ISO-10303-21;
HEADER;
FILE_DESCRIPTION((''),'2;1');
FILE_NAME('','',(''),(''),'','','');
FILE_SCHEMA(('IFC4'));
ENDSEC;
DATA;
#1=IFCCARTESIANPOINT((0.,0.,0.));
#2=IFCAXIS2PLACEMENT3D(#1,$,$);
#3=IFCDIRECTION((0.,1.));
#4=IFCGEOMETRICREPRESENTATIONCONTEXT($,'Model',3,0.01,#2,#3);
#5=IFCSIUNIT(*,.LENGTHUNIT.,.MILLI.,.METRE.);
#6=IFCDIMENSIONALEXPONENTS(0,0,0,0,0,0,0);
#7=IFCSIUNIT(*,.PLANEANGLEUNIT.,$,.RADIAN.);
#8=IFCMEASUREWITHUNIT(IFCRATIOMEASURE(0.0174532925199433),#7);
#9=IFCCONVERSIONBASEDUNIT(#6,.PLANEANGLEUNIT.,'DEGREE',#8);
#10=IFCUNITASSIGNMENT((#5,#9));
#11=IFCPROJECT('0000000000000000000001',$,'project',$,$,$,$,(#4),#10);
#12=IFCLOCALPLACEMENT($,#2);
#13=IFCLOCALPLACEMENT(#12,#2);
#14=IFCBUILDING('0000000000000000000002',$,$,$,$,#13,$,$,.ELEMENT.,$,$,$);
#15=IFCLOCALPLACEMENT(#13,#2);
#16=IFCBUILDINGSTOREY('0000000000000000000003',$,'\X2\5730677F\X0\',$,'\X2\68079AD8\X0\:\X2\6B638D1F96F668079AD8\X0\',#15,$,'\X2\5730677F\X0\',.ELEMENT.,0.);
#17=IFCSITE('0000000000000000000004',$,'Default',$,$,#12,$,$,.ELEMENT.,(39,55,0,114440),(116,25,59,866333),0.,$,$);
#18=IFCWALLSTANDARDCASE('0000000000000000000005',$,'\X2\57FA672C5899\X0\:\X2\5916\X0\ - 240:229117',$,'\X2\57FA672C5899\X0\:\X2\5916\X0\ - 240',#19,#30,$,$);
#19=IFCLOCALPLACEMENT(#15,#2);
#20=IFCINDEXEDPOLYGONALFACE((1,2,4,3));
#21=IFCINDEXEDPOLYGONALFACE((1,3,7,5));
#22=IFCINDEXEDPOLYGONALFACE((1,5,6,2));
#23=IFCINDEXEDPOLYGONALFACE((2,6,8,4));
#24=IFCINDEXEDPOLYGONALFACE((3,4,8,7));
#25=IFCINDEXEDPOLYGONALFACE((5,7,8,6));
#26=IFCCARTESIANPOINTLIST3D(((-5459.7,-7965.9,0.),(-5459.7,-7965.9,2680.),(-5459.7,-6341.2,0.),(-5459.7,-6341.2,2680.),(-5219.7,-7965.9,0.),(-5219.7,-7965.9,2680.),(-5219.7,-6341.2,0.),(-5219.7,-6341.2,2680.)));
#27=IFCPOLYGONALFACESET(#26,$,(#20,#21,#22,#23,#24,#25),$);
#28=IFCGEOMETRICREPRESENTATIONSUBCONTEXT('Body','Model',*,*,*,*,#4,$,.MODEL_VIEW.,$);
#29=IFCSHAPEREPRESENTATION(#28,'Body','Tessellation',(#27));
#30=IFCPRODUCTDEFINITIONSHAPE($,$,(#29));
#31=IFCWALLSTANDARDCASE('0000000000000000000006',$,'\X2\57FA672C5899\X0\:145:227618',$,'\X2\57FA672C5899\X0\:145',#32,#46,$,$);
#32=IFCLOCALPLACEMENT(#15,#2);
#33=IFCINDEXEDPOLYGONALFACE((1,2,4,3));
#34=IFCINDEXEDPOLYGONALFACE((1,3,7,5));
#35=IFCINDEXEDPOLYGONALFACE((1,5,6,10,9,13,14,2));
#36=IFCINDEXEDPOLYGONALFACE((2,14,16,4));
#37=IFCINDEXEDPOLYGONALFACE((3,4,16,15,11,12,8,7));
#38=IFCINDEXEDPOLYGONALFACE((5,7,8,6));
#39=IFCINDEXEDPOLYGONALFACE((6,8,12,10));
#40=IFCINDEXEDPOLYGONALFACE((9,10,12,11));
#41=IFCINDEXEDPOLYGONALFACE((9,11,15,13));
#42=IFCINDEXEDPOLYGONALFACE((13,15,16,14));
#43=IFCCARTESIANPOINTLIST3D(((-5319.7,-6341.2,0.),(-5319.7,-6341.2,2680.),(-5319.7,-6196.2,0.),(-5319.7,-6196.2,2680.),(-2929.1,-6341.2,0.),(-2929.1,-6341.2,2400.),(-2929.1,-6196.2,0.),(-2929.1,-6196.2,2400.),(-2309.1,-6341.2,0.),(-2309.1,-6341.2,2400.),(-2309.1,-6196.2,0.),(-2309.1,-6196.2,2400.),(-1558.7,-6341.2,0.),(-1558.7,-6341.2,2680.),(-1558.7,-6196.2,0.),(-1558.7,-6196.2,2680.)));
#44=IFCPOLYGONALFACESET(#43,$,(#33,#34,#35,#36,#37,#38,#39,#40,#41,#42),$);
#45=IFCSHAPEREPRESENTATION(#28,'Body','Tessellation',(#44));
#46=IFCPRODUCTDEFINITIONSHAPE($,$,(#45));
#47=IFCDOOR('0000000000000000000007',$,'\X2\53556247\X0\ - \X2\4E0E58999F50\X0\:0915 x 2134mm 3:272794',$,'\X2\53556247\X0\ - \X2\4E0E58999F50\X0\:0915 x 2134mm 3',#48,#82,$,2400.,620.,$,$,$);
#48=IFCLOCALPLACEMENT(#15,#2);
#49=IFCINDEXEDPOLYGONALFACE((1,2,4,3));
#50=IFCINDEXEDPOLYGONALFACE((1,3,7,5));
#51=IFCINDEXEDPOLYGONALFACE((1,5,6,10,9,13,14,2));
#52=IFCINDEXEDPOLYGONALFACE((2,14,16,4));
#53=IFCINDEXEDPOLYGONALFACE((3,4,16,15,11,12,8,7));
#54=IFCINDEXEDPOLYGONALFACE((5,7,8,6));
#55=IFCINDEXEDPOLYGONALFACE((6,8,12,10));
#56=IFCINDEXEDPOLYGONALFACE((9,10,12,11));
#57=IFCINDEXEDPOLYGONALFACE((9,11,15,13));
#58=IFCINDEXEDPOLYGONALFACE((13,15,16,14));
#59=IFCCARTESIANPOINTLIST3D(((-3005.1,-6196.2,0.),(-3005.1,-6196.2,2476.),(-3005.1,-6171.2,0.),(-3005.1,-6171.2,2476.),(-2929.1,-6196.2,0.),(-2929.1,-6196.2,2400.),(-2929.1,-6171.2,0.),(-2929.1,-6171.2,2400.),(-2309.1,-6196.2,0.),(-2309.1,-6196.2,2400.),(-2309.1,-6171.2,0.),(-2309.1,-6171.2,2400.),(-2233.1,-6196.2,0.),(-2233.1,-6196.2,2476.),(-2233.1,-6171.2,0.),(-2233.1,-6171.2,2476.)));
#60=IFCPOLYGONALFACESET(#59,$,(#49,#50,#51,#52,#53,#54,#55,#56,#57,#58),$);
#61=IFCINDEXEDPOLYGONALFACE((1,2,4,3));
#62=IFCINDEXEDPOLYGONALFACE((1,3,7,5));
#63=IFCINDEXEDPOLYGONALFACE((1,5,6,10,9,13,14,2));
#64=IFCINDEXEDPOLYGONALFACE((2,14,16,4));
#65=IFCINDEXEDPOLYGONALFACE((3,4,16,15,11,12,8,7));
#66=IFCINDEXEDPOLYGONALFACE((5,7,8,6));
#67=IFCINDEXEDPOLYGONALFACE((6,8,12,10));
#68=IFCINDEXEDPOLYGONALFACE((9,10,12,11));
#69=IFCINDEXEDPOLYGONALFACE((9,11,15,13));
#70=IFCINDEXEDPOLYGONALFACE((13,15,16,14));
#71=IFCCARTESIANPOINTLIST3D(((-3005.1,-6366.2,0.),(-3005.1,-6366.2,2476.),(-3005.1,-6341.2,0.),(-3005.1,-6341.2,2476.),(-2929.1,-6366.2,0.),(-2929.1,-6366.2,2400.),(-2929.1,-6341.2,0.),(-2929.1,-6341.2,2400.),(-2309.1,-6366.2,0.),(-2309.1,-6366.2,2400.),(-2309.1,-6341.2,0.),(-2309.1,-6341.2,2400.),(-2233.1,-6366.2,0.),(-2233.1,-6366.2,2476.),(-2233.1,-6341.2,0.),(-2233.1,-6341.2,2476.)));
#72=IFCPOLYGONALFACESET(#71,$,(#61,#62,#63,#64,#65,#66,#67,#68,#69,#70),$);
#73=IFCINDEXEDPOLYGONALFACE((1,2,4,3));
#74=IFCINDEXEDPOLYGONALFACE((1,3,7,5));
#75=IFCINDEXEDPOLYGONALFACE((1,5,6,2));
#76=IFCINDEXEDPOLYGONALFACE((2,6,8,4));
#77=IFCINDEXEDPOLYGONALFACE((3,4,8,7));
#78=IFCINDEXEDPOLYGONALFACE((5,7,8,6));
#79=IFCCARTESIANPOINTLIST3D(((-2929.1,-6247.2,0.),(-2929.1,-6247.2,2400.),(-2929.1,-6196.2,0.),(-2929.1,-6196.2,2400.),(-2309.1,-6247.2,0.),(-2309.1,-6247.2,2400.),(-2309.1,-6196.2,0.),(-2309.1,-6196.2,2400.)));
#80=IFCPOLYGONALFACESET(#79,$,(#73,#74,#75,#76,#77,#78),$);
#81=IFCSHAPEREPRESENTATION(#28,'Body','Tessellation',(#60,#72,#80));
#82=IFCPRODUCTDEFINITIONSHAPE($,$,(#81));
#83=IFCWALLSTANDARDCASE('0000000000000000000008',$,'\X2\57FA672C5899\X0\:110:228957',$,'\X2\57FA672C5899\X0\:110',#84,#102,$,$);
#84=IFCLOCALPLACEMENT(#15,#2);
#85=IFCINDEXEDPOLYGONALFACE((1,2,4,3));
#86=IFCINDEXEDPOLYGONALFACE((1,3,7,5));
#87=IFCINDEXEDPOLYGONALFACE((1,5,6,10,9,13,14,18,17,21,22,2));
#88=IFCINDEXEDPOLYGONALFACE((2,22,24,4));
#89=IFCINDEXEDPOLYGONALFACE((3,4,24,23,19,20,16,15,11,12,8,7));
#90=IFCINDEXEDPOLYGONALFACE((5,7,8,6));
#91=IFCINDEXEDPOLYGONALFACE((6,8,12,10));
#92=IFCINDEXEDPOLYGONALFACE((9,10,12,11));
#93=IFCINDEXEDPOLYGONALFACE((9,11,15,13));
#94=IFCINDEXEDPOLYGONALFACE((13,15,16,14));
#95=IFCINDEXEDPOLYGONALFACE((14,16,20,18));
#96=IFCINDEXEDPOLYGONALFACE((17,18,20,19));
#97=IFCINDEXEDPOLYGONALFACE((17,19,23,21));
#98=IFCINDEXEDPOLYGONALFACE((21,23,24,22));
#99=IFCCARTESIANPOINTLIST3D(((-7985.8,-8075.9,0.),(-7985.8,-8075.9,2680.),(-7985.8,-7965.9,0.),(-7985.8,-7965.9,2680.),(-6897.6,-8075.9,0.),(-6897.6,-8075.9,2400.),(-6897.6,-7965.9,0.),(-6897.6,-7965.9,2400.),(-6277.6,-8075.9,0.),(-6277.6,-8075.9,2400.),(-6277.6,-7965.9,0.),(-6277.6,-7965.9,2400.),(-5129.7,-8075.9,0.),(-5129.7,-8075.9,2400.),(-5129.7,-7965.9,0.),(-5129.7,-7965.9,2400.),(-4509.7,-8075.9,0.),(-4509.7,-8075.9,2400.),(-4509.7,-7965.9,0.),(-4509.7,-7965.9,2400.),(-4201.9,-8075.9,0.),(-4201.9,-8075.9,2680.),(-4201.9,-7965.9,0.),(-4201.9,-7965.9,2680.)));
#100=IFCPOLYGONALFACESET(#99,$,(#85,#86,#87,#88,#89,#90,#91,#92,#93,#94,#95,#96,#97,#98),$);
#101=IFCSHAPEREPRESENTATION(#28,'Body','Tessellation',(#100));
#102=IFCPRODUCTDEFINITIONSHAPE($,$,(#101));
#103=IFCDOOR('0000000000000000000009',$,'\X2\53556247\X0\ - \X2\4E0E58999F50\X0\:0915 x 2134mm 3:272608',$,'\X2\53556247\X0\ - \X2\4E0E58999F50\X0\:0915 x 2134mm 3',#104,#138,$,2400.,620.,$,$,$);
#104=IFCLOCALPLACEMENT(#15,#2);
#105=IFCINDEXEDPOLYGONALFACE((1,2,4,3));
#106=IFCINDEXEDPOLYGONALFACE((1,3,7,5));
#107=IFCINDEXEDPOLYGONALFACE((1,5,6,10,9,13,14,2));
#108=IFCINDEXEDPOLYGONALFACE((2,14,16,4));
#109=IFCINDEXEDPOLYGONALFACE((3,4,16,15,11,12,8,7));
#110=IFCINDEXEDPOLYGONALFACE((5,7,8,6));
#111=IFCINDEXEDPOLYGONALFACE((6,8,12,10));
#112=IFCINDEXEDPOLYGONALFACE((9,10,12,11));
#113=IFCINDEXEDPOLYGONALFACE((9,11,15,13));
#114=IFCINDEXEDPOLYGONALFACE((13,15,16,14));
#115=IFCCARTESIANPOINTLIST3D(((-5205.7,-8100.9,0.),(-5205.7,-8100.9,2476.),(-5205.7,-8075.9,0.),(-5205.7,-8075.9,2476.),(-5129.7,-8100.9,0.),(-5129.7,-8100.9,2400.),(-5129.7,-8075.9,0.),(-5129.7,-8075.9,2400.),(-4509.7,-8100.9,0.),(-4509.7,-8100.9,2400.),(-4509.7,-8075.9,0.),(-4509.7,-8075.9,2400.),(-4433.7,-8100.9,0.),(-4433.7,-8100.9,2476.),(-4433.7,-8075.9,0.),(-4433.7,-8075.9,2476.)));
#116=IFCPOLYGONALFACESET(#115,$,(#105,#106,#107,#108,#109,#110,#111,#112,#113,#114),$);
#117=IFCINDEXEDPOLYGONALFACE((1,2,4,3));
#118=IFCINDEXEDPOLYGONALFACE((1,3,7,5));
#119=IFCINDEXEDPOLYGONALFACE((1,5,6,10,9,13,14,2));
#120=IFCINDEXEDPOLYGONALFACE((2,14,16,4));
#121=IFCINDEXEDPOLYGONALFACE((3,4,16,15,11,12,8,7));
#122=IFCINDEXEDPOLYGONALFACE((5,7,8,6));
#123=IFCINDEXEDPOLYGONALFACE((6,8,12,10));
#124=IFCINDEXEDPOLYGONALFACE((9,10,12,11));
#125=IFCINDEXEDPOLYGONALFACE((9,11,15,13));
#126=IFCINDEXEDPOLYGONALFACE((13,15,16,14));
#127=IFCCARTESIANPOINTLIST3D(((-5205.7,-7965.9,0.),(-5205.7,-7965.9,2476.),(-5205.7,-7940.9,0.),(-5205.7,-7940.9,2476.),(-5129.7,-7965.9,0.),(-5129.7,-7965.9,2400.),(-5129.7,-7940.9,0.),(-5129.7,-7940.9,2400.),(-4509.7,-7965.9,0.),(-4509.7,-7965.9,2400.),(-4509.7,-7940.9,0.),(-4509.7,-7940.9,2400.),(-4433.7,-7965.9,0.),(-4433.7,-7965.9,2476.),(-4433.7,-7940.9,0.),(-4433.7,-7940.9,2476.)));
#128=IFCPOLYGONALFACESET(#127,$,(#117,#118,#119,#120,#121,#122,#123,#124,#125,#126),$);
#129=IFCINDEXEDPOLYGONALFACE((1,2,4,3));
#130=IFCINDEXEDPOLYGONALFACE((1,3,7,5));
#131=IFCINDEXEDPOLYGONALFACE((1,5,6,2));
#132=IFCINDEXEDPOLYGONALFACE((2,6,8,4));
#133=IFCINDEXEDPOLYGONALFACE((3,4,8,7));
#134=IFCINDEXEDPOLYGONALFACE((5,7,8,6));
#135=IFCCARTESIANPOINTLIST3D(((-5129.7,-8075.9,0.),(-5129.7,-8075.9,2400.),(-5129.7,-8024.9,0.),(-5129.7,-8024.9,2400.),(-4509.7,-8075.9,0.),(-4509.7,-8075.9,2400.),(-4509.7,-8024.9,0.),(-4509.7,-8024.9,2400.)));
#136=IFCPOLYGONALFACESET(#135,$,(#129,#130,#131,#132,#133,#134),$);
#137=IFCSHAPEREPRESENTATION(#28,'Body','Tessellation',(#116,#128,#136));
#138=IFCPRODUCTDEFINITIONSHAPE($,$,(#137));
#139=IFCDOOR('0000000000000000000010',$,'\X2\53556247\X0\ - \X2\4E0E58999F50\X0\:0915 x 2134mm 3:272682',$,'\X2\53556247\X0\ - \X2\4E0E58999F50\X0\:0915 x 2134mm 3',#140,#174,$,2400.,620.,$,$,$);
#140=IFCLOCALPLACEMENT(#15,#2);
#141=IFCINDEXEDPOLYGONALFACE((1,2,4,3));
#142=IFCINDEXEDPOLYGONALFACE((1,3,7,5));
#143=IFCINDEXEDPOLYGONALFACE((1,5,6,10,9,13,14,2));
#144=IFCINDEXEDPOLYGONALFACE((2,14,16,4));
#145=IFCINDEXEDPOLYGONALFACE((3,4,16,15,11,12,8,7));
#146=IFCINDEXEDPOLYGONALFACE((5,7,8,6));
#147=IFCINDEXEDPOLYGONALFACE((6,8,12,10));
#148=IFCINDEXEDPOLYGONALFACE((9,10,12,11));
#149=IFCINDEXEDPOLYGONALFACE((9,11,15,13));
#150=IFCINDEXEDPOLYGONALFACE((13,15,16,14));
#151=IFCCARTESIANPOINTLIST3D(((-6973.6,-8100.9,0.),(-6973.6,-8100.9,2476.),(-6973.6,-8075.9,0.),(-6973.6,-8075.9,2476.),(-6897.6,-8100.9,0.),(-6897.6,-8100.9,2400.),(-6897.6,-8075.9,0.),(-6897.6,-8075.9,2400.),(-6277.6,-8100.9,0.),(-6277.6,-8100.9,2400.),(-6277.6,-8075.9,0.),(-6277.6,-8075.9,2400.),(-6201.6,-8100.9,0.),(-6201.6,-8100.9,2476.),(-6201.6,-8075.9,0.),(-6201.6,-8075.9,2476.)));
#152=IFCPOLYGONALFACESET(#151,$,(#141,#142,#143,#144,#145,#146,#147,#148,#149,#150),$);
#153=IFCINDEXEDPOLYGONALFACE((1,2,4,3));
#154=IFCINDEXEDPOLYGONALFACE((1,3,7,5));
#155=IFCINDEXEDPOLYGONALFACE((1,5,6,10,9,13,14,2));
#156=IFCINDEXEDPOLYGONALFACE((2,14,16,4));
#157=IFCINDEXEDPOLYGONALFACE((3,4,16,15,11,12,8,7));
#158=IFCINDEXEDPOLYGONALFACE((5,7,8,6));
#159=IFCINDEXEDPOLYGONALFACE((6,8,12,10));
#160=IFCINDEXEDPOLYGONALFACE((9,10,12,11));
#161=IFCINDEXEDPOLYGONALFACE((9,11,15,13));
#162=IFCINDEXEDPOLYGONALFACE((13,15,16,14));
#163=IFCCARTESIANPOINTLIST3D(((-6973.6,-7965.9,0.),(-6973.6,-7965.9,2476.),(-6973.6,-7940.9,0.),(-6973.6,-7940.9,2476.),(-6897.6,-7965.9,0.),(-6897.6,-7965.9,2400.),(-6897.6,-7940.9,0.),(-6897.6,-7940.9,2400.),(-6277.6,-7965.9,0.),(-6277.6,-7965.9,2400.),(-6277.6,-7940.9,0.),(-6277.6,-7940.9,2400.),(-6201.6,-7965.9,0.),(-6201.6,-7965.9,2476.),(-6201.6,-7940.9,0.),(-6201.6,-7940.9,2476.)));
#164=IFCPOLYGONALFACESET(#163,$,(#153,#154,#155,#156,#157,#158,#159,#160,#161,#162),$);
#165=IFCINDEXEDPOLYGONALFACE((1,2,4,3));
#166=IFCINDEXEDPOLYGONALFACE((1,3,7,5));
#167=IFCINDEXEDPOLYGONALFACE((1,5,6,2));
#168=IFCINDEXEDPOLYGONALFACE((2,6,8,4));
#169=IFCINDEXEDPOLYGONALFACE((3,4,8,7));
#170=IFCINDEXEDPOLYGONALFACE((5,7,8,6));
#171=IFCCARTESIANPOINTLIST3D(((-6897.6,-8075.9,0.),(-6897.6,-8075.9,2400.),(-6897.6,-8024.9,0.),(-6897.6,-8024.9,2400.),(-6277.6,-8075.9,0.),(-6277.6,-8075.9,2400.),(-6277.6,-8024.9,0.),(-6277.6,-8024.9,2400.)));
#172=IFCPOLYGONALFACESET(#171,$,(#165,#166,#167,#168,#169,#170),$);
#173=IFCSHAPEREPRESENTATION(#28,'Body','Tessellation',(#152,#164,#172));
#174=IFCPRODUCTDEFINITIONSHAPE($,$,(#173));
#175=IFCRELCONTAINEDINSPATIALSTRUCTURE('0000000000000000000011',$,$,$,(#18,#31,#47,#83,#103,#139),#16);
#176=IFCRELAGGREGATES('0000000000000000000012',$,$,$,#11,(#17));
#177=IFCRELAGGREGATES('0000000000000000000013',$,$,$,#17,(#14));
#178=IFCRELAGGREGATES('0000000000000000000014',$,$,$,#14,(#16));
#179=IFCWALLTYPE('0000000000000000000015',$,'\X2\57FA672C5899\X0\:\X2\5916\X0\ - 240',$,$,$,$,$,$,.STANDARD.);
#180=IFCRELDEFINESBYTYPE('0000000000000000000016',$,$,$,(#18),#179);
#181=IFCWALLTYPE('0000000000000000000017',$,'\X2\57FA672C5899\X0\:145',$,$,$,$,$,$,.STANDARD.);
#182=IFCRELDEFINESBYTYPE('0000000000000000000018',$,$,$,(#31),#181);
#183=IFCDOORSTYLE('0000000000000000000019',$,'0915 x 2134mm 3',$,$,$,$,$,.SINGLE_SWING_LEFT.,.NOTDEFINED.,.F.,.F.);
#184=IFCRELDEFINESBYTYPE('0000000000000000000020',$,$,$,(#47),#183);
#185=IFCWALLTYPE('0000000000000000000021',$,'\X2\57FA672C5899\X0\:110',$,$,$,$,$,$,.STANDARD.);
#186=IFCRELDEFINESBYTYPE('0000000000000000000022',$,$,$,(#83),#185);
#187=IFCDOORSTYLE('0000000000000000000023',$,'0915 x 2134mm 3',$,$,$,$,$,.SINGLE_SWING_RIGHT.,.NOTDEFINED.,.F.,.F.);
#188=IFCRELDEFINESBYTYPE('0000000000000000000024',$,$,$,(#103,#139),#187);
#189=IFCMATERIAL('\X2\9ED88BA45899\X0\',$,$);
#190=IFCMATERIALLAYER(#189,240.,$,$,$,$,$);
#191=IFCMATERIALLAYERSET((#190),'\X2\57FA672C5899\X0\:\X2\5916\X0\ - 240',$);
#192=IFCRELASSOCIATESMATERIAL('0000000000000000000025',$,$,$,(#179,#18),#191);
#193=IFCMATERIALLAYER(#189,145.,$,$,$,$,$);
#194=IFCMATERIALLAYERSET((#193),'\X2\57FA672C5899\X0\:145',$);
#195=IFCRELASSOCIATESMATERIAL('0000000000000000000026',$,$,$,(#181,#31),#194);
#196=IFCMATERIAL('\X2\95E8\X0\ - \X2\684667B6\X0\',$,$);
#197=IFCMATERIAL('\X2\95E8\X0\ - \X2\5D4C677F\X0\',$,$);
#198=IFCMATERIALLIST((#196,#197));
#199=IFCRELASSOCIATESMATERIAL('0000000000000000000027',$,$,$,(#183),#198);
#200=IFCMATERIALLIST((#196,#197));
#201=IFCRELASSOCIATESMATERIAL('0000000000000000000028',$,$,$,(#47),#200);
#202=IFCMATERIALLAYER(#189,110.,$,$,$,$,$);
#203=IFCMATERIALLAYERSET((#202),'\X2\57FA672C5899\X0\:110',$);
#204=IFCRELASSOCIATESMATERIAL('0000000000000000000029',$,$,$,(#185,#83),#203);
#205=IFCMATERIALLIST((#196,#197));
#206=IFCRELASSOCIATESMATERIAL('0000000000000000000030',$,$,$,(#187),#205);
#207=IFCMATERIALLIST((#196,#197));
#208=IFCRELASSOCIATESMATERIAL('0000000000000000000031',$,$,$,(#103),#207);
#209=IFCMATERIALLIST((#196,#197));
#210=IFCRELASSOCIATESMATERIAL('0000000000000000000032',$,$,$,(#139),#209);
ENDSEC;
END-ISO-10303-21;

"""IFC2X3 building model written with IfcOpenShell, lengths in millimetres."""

from ifc_helpers import new_model, entity, si_unit, converted_unit, direction, frame, frame_2d, origin, origin_2d_with_axis, place, context, subcontext, project, spatial, polyline, rectangle, outline, extrude, source, transform, mapped, material, material_list, layer, layer_set, layer_usage, type_object, type_shapes, element, fill, save


model = new_model("IFC2X3")

# Units and contexts
model_context = context("Model", 3, precision=0.01, world=origin(), true_north=direction((0.0, 1.0)))
body_context = subcontext(model_context, "Body", "Model", "MODEL_VIEW")
ifc_project = project(units=[si_unit("LENGTHUNIT", "METRE", prefix="MILLI"), converted_unit("PLANEANGLEUNIT", "DEGREE", entity("IfcRatioMeasure", 0.0174532925199433), si_unit("PLANEANGLEUNIT", "RADIAN"), dimensions=[0, 0, 0, 0, 0, 0, 0])], contexts=[model_context])

# Site, building, storey
site_placement = place(None, origin())
site = spatial("IfcSite", under=ifc_project, at=site_placement, Name="Default", CompositionType="ELEMENT", RefLatitude=(39, 55, 0, 114440), RefLongitude=(116, 25, 59, 866333), RefElevation=0.0)
building_placement = place(site_placement, origin())
building = spatial("IfcBuilding", under=site, at=building_placement, CompositionType="ELEMENT")
storey_placement = place(building_placement, origin())
storey = spatial("IfcBuildingStorey", under=building, at=storey_placement, Name="地板", ObjectType="标高:正负零标高", LongName="地板", CompositionType="ELEMENT", Elevation=0.0)

# Shared definitions
ifc_material_1 = material(Name="默认墙")
ifc_layer_1 = layer(ifc_material_1, 240.0)
ifc_layer_set_1 = layer_set([ifc_layer_1], Name="基本墙:外 - 240")
wall_type_1 = type_object("IfcWallType", Name="基本墙:外 - 240", PredefinedType="STANDARD", material=ifc_layer_set_1)

# Wall
ifc_layer_usage_1 = layer_usage(ifc_layer_set_1, "AXIS2", "NEGATIVE", 120.0)
wall_1_placement = place(storey_placement, frame((-5339.7, -6341.2, 0.0), z_axis=(0.0, 0.0, 1.0), x_axis=(0.0, -1.0, 0.0)))
element("IfcWallStandardCase", 1, at=wall_1_placement, inside=storey, type_object=wall_type_1, material=ifc_layer_usage_1, Name="基本墙:外 - 240:229117", ObjectType="基本墙:外 - 240", context=body_context, shape_type="SweptSolid", body=[
    extrude(rectangle(XDim=1624.7, YDim=240.0, at=frame_2d((812.3, 0.0), x_axis=(-1.0, 0.0))), origin(), (0.0, 0.0, 1.0), 2680.0),
])

# Wall, opening, door
ifc_layer_2 = layer(ifc_material_1, 145.0)
ifc_layer_set_2 = layer_set([ifc_layer_2], Name="基本墙:145")
ifc_layer_usage_2 = layer_usage(ifc_layer_set_2, "AXIS2", "NEGATIVE", 72.5)
wall_type_2 = type_object("IfcWallType", Name="基本墙:145", PredefinedType="STANDARD", material=ifc_layer_set_2)
wall_2_placement = place(storey_placement, frame((-5319.7, -6268.7, 0.0)))
wall_2 = element("IfcWallStandardCase", 2, at=wall_2_placement, inside=storey, type_object=wall_type_2, material=ifc_layer_usage_2, Name="基本墙:145:227618", ObjectType="基本墙:145", context=body_context, shape_type="SweptSolid", body=[
    extrude(rectangle(XDim=3761.0, YDim=145.0, at=frame_2d((1880.5, 0.0), x_axis=(-1.0, 0.0))), origin(), (0.0, 0.0, 1.0), 2680.0),
])
opening_1_placement = place(wall_2_placement, frame((2390.6, -72.5, 0.0)))
opening_1 = element("IfcOpeningElement", 3, at=opening_1_placement, cuts=wall_2, ObjectType="Opening", context=body_context, shape_type="SweptSolid", body=[
    extrude(rectangle(XDim=620.0, YDim=2400.0, at=frame_2d((1200.0, 310.0), x_axis=(0.0, -1.0))), frame((0.0, 0.0, 0.0), z_axis=(0.0, 1.0, 0.0), x_axis=(0.0, 0.0, 1.0)), (0.0, 0.0, 1.0), 145.0),
])
ifc_material_2 = material(Name="门 - 框架")
ifc_material_3 = material(Name="门 - 嵌板")
ifc_material_list_1 = material_list([ifc_material_2, ifc_material_3])
ifc_material_list_2 = material_list([ifc_material_2, ifc_material_3])
door_style_1 = type_object("IfcDoorStyle", Name="0915 x 2134mm 3", ConstructionType="NOTDEFINED", OperationType="SINGLE_SWING_LEFT", ParameterTakesPrecedence=False, Sizeable=False, material=ifc_material_list_2)
shared_shape_1 = source(origin(), body_context, "Body", "SweptSolid", [
    extrude(outline(polyline([(-386.0, -1257.0), (386.0, -1257.0), (386.0, 1219.0), (310.0, 1219.0), (310.0, -1181.0), (-310.0, -1181.0), (-310.0, 1219.0), (-386.0, 1219.0), (-386.0, -1257.0)])), frame((310.0, 170.0, 1219.0), z_axis=(0.0, -1.0, 0.0), x_axis=(-1.0, 0.0, 0.0)), (0.0, 0.0, 1.0), 25.0),
    extrude(outline(polyline([(-1257.0, -386.0), (1219.0, -386.0), (1219.0, -310.0), (-1181.0, -310.0), (-1181.0, 310.0), (1219.0, 310.0), (1219.0, 386.0), (-1257.0, 386.0), (-1257.0, -386.0)])), frame((310.0, 0.0, 1219.0), z_axis=(0.0, -1.0, 0.0), x_axis=(0.0, 0.0, -1.0)), (0.0, 0.0, 1.0), 25.0),
    extrude(rectangle(XDim=620.0, YDim=51.0, at=frame_2d((0.0, 0.0), x_axis=(1.0, 0.0))), frame((310.0, 119.5, 0.0)), (0.0, 0.0, 1.0), 2400.0),
])
type_shapes(door_style_1, [shared_shape_1])
door_1_placement = place(opening_1_placement, origin())
door_1 = element("IfcDoor", 4, at=door_1_placement, inside=storey, type_object=door_style_1, material=ifc_material_list_1, Name="单扇 - 与墙齐:0915 x 2134mm 3:272794", ObjectType="单扇 - 与墙齐:0915 x 2134mm 3", OverallHeight=2400.0, OverallWidth=620.0, context=body_context, shape_type="MappedRepresentation", body=[
    mapped(shared_shape_1, transform((0.0, 0.0, 0.0), scale=1.0)),
])
fill(opening_1, door_1)

# Wall, openings, doors
ifc_layer_3 = layer(ifc_material_1, 110.0)
ifc_layer_set_3 = layer_set([ifc_layer_3], Name="基本墙:110")
ifc_layer_usage_3 = layer_usage(ifc_layer_set_3, "AXIS2", "NEGATIVE", 55.0)
wall_type_3 = type_object("IfcWallType", Name="基本墙:110", PredefinedType="STANDARD", material=ifc_layer_set_3)
wall_3_placement = place(storey_placement, frame((-7985.8, -8020.9, 0.0)))
wall_3 = element("IfcWallStandardCase", 5, at=wall_3_placement, inside=storey, type_object=wall_type_3, material=ifc_layer_usage_3, Name="基本墙:110:228957", ObjectType="基本墙:110", context=body_context, shape_type="SweptSolid", body=[
    extrude(rectangle(XDim=3783.9, YDim=110.0, at=frame_2d((1891.9, 0.0), x_axis=(-1.0, 0.0))), origin(), (0.0, 0.0, 1.0), 2680.0),
])
opening_2_placement = place(wall_3_placement, frame((3476.1, 55.0, 0.0)))
opening_2 = element("IfcOpeningElement", 6, at=opening_2_placement, cuts=wall_3, ObjectType="Opening", context=body_context, shape_type="SweptSolid", body=[
    extrude(rectangle(XDim=620.0, YDim=2400.0, at=frame_2d((1200.0, 310.0), x_axis=(0.0, 1.0))), frame((0.0, 0.0, 0.0), z_axis=(0.0, -1.0, 0.0), x_axis=(0.0, 0.0, 1.0)), (0.0, 0.0, 1.0), 110.0),
])
opening_3_placement = place(wall_3_placement, frame((1708.2, 55.0, 0.0)))
opening_3 = element("IfcOpeningElement", 7, at=opening_3_placement, cuts=wall_3, ObjectType="Opening", context=body_context, shape_type="SweptSolid", body=[
    extrude(rectangle(XDim=620.0, YDim=2400.0, at=frame_2d((1200.0, 310.0), x_axis=(0.0, 1.0))), frame((0.0, 0.0, 0.0), z_axis=(0.0, -1.0, 0.0), x_axis=(0.0, 0.0, 1.0)), (0.0, 0.0, 1.0), 110.0),
])
ifc_material_list_3 = material_list([ifc_material_2, ifc_material_3])
ifc_material_list_4 = material_list([ifc_material_2, ifc_material_3])
door_style_2 = type_object("IfcDoorStyle", Name="0915 x 2134mm 3", ConstructionType="NOTDEFINED", OperationType="SINGLE_SWING_RIGHT", ParameterTakesPrecedence=False, Sizeable=False, material=ifc_material_list_4)
shared_shape_2 = source(origin(), body_context, "Body", "SweptSolid", [
    extrude(outline(polyline([(-386.0, -1257.0), (386.0, -1257.0), (386.0, 1219.0), (310.0, 1219.0), (310.0, -1181.0), (-310.0, -1181.0), (-310.0, 1219.0), (-386.0, 1219.0), (-386.0, -1257.0)])), frame((310.0, 110.0, 1219.0), z_axis=(0.0, 1.0, 0.0), x_axis=(1.0, 0.0, 0.0)), (0.0, 0.0, 1.0), 25.0),
    extrude(outline(polyline([(-1257.0, -386.0), (1219.0, -386.0), (1219.0, -310.0), (-1181.0, -310.0), (-1181.0, 310.0), (1219.0, 310.0), (1219.0, 386.0), (-1257.0, 386.0), (-1257.0, -386.0)])), frame((310.0, -25.0, 1219.0), z_axis=(0.0, 1.0, 0.0), x_axis=(0.0, 0.0, -1.0)), (0.0, 0.0, 1.0), 25.0),
    extrude(rectangle(XDim=51.0, YDim=620.0, at=origin_2d_with_axis()), frame((310.0, 84.5, 0.0), z_axis=(0.0, 0.0, 1.0), x_axis=(0.0, 1.0, 0.0)), (0.0, 0.0, 1.0), 2400.0),
])
type_shapes(door_style_2, [shared_shape_2])
door_2_placement = place(opening_2_placement, frame((0.0, 0.0, 0.0), z_axis=(0.0, 0.0, 1.0), x_axis=(-1.0, 0.0, 0.0)))
door_2 = element("IfcDoor", 8, at=door_2_placement, inside=storey, type_object=door_style_2, material=ifc_material_list_3, Name="单扇 - 与墙齐:0915 x 2134mm 3:272608", ObjectType="单扇 - 与墙齐:0915 x 2134mm 3", OverallHeight=2400.0, OverallWidth=620.0, context=body_context, shape_type="MappedRepresentation", body=[
    mapped(shared_shape_2, transform((0.0, 0.0, 0.0), scale=1.0)),
])
fill(opening_2, door_2)
ifc_material_list_5 = material_list([ifc_material_2, ifc_material_3])
door_3_placement = place(opening_3_placement, frame((0.0, 0.0, 0.0), z_axis=(0.0, 0.0, 1.0), x_axis=(-1.0, 0.0, 0.0)))
door_3 = element("IfcDoor", 9, at=door_3_placement, inside=storey, type_object=door_style_2, material=ifc_material_list_5, Name="单扇 - 与墙齐:0915 x 2134mm 3:272682", ObjectType="单扇 - 与墙齐:0915 x 2134mm 3", OverallHeight=2400.0, OverallWidth=620.0, context=body_context, shape_type="MappedRepresentation", body=[
    mapped(shared_shape_2, transform((0.0, 0.0, 0.0), scale=1.0)),
])
fill(opening_3, door_3)

save(model, "model.ifc")
